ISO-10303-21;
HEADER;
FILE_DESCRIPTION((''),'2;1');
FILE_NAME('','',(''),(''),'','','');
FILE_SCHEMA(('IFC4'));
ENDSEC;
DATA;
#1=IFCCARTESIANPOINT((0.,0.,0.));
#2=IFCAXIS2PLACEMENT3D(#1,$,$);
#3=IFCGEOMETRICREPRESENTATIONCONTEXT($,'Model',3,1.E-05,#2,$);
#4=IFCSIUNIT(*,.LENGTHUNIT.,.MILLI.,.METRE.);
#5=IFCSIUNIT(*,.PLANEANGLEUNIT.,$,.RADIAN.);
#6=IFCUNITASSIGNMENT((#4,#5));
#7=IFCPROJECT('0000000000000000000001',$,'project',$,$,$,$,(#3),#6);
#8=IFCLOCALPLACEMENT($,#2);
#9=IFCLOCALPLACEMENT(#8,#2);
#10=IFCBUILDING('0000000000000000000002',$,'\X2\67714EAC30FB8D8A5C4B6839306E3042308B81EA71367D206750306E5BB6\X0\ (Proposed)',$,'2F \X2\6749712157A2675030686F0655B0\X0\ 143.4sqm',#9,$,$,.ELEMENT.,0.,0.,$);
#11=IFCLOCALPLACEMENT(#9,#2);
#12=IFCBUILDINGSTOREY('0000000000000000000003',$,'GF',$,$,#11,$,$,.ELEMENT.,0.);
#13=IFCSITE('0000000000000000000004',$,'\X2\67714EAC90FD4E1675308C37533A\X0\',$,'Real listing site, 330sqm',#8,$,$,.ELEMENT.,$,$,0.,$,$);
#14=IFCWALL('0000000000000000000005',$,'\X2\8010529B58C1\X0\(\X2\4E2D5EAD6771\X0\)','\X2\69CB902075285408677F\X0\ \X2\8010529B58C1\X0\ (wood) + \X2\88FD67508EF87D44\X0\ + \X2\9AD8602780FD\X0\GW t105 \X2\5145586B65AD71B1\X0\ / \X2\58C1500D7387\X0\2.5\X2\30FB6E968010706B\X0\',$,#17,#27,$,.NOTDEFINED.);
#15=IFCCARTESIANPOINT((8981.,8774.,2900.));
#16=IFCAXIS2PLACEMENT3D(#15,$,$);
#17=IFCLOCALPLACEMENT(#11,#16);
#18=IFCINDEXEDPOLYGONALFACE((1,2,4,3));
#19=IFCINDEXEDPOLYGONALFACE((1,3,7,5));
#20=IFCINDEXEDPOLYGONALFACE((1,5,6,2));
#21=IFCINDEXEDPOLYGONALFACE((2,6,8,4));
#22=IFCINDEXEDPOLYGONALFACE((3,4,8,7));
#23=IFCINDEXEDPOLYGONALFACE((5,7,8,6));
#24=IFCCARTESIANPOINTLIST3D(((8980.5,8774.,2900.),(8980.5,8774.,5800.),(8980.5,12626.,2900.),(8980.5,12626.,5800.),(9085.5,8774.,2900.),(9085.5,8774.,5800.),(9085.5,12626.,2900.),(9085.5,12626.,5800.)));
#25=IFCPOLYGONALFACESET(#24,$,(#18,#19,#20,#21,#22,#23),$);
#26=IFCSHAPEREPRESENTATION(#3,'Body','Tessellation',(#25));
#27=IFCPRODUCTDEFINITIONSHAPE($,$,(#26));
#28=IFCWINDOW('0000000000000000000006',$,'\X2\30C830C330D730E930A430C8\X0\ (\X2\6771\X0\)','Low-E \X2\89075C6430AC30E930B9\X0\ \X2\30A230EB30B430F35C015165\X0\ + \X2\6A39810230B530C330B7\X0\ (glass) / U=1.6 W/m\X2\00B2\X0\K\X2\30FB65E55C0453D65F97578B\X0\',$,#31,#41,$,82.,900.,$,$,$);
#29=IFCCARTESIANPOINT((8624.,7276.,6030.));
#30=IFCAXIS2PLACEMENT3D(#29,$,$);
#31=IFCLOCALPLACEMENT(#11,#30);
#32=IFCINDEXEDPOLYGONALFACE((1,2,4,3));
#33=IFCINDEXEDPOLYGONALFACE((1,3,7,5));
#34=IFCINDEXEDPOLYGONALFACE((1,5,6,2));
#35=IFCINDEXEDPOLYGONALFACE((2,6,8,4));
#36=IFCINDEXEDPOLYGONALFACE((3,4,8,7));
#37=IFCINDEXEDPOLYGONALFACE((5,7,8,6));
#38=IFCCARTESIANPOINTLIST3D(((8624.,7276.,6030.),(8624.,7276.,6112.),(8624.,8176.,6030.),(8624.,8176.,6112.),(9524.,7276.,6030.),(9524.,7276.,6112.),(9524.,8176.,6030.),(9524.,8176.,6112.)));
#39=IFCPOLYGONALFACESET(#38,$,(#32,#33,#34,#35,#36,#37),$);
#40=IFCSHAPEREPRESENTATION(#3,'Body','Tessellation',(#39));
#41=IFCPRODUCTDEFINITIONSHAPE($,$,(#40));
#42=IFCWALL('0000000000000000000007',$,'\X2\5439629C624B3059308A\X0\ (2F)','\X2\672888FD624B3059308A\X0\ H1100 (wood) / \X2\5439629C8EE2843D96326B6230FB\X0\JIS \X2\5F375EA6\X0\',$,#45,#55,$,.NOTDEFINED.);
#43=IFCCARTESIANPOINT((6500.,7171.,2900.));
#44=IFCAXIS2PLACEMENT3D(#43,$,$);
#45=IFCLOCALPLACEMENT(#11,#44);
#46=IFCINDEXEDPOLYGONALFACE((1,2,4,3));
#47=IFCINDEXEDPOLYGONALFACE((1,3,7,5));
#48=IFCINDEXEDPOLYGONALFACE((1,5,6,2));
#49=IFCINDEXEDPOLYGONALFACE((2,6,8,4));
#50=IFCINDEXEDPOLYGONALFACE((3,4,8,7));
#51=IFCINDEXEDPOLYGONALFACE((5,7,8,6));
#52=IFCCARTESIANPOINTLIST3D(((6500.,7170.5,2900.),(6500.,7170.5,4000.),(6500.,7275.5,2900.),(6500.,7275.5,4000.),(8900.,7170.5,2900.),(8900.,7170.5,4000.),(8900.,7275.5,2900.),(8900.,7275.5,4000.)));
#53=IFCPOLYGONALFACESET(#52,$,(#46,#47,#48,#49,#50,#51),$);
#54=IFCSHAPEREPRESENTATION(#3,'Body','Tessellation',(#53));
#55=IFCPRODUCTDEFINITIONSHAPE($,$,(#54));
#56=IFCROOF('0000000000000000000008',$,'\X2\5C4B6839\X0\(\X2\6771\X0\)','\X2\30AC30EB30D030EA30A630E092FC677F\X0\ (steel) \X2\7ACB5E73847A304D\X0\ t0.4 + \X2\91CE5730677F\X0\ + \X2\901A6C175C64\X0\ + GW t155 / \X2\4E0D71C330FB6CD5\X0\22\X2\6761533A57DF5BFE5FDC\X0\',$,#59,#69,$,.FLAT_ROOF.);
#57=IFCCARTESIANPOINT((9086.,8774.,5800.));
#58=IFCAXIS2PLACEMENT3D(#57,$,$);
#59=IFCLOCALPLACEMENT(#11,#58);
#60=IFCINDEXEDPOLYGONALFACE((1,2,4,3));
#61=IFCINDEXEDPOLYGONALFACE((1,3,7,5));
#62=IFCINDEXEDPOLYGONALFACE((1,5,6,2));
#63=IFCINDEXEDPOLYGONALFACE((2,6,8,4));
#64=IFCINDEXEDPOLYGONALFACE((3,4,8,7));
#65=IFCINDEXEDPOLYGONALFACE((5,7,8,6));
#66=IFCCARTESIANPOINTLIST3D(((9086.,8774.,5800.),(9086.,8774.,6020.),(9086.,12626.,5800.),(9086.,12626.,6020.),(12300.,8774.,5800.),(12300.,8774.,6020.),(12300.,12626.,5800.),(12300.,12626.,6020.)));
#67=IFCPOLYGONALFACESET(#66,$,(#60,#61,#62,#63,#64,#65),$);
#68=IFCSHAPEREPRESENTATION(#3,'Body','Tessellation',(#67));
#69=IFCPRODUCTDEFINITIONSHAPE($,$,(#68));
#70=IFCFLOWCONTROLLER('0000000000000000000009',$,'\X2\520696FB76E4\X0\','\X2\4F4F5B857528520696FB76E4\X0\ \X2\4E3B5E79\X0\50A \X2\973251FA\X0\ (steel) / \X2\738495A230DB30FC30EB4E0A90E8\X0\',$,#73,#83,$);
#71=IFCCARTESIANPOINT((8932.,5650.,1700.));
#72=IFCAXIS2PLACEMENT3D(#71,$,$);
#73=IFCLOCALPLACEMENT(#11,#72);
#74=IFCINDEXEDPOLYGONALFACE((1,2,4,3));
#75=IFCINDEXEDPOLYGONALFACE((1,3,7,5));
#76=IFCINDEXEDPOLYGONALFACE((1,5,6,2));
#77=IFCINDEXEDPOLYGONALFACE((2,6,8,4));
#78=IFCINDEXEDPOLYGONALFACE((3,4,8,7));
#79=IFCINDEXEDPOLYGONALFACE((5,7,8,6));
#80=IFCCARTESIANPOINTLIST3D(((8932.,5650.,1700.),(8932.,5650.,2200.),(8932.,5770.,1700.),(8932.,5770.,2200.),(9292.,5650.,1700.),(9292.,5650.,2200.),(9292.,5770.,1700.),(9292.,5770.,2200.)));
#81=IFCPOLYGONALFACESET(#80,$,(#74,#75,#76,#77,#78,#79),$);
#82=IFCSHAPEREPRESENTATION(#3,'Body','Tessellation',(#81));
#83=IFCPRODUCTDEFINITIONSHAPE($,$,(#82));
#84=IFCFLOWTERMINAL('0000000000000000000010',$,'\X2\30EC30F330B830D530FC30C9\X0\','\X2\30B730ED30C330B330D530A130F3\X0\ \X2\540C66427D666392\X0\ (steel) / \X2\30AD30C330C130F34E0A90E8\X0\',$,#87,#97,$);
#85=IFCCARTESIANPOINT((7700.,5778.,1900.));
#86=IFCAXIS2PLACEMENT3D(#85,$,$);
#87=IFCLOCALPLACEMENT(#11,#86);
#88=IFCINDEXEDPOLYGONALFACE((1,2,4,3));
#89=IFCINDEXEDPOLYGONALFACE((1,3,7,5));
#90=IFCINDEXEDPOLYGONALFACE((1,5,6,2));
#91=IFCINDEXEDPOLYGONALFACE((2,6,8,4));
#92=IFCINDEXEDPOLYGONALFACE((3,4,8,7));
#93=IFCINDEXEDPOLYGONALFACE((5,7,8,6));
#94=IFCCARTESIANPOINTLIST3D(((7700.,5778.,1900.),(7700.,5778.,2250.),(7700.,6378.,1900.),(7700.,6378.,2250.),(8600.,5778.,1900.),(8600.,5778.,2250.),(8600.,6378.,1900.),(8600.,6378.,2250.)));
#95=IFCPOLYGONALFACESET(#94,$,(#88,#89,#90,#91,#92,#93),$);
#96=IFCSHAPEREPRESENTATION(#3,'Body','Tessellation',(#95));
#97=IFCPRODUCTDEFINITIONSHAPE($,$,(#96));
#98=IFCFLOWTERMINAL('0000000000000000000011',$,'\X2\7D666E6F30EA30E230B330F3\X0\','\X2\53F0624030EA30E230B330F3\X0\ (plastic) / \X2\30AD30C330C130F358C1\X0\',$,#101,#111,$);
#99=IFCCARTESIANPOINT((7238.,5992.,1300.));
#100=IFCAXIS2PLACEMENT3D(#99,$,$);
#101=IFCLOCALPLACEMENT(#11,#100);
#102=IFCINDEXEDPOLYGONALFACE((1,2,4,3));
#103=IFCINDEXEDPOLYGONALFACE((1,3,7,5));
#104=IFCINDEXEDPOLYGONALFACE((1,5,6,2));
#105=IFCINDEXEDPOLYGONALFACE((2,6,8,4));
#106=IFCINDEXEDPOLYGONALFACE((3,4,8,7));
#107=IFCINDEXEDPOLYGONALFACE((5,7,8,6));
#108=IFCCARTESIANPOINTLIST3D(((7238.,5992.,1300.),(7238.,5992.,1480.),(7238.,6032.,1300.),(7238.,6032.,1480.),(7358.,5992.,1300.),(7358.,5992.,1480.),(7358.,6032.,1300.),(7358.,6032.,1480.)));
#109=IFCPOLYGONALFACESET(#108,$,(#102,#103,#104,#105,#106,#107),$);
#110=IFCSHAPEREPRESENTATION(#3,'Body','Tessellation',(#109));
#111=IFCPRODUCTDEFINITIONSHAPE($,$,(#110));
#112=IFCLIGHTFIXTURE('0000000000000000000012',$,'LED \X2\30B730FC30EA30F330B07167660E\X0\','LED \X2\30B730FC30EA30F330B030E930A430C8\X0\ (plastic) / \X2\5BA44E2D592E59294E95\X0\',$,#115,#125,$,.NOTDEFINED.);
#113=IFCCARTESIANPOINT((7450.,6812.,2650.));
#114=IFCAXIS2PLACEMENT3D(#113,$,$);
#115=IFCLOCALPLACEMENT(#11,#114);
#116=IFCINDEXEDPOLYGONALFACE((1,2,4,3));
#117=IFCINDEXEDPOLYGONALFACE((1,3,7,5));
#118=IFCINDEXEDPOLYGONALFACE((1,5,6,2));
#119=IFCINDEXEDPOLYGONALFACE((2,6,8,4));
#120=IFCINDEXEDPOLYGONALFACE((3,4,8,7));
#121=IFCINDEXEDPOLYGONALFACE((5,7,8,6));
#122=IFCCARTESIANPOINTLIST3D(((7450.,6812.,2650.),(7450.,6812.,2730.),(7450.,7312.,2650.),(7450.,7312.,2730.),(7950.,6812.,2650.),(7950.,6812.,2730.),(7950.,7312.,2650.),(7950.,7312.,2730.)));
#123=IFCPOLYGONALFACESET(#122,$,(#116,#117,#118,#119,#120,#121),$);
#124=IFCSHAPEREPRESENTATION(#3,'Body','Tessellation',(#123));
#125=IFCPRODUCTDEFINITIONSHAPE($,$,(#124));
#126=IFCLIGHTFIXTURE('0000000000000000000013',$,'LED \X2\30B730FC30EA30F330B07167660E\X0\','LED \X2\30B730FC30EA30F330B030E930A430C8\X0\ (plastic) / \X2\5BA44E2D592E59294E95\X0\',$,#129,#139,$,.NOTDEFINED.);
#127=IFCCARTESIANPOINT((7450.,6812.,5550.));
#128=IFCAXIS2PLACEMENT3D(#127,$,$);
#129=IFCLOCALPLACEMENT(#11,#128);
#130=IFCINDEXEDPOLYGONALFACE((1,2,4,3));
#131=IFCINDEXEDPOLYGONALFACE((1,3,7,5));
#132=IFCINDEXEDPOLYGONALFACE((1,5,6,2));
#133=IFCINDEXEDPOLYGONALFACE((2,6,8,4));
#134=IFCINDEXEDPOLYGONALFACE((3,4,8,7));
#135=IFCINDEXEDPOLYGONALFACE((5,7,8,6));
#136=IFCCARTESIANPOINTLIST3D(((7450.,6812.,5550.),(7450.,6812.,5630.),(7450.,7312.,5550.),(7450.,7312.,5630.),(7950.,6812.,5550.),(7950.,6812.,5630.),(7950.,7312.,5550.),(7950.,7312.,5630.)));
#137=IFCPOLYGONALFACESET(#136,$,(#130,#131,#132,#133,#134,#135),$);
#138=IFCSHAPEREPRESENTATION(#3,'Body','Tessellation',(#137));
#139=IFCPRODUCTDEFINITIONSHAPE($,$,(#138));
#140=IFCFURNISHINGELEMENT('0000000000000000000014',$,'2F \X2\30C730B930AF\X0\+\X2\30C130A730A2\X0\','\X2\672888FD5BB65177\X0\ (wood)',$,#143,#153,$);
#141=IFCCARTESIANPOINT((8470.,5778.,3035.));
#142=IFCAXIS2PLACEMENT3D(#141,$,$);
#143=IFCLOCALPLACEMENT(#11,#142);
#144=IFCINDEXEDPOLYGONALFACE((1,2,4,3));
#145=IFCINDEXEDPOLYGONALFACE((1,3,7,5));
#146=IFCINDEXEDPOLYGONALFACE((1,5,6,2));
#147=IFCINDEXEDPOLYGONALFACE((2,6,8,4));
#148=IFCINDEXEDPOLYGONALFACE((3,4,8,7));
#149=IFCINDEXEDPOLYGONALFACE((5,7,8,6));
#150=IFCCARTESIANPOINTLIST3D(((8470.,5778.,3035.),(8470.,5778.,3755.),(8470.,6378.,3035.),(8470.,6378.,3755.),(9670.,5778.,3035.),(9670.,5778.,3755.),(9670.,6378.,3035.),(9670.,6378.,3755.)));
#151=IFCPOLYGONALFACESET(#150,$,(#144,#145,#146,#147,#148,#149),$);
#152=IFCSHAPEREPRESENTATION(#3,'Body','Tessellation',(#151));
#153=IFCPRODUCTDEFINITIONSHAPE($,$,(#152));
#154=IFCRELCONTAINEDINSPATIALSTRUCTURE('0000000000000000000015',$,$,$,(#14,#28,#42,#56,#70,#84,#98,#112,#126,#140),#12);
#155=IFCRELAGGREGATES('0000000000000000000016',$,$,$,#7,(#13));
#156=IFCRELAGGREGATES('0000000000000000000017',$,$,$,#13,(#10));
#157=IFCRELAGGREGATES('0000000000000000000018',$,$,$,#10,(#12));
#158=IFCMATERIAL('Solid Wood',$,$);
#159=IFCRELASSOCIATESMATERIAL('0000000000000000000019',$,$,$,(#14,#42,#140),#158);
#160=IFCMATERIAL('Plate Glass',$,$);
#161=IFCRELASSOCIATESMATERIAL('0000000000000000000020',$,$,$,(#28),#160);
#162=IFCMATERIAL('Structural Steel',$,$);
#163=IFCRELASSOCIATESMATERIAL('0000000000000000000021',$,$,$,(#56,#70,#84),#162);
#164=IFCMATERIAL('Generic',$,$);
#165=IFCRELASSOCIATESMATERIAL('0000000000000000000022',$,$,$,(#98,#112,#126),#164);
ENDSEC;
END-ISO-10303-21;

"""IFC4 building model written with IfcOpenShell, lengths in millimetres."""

from ifc_helpers import new_model, si_unit, frame, frame_2d, origin, place, context, project, spatial, rectangle, extrude, material, element, save


model = new_model("IFC4")

# Units and contexts
model_context = context("Model", 3, precision=1e-05, world=origin())
ifc_project = project(units=[si_unit("LENGTHUNIT", "METRE", prefix="MILLI"), si_unit("PLANEANGLEUNIT", "RADIAN")], contexts=[model_context])

# Site, building, storey
site_placement = place(None, origin())
site = spatial("IfcSite", under=ifc_project, at=site_placement, Name="東京都世田谷区", ObjectType="Real listing site, 330sqm", CompositionType="ELEMENT", RefElevation=0.0)
building_placement = place(site_placement, origin())
building = spatial("IfcBuilding", under=site, at=building_placement, Name="東京・越屋根のある自然素材の家 (Proposed)", ObjectType="2F 杉無垢材と漆喰 143.4sqm", CompositionType="ELEMENT", ElevationOfRefHeight=0.0, ElevationOfTerrain=0.0)
storey_placement = place(building_placement, origin())
storey = spatial("IfcBuildingStorey", under=building, at=storey_placement, Name="GF", CompositionType="ELEMENT", Elevation=0.0)

# Shared definitions
ifc_material_1 = material(Name="Solid Wood")

# Shared definitions
ifc_material_2 = material(Name="Plate Glass")

# Wall
wall_1_placement = place(storey_placement, frame((8981.0, 8774.0, 2900.0)))
element("IfcWall", 1, at=wall_1_placement, inside=storey, material=ifc_material_1, Name="耐力壁(中庭東)", Description="構造用合板 耐力壁 (wood) + 製材軸組 + 高性能GW t105 充填断熱 / 壁倍率2.5・準耐火", PredefinedType="NOTDEFINED", context=model_context, shape_type="SweptSolid", body=[
    extrude(rectangle(XDim=105.0, YDim=3852.0, at=frame_2d((52.0, 1926.0))), frame((8981.0, 8774.0, 2900.0)), (0.0, 0.0, 1.0), 2900.0),
])

# Window
window_1_placement = place(storey_placement, frame((8624.0, 7276.0, 6030.0)))
element("IfcWindow", 2, at=window_1_placement, inside=storey, material=ifc_material_2, Name="トップライト (東)", Description="Low-E 複層ガラス アルゴン封入 + 樹脂サッシ (glass) / U=1.6 W/m²K・日射取得型", OverallHeight=82.0, OverallWidth=900.0, context=model_context, shape_type="SweptSolid", body=[
    extrude(rectangle(XDim=900.0, YDim=900.0, at=frame_2d((450.0, 450.0))), frame((8624.0, 7276.0, 6030.0)), (0.0, 0.0, 1.0), 82.0),
])

# Wall
wall_2_placement = place(storey_placement, frame((6500.0, 7171.0, 2900.0)))
element("IfcWall", 3, at=wall_2_placement, inside=storey, material=ifc_material_1, Name="吹抜手すり (2F)", Description="木製手すり H1100 (wood) / 吹抜転落防止・JIS 強度", PredefinedType="NOTDEFINED", context=model_context, shape_type="SweptSolid", body=[
    extrude(rectangle(XDim=2400.0, YDim=105.0, at=frame_2d((1200.0, 52.0))), frame((6500.0, 7171.0, 2900.0)), (0.0, 0.0, 1.0), 1100.0),
])

# Roof
ifc_material_3 = material(Name="Structural Steel")
for number, where, name in (
    (4, (9086.0, 8774.0, 5800.0), "屋根(東)"),
):
    element("IfcRoof", number, at=place(storey_placement, frame(where)), inside=storey, material=ifc_material_3, Name=name, Description="ガルバリウム鋼板 (steel) 立平葺き t0.4 + 野地板 + 通気層 + GW t155 / 不燃・法22条区域対応", PredefinedType="FLAT_ROOF", context=model_context, shape_type="SweptSolid", body=[
        extrude(rectangle(XDim=3214.0, YDim=3852.0, at=frame_2d((1607.0, 1926.0))), frame((9086.0, 8774.0, 5800.0)), (0.0, 0.0, 1.0), 220.0),
    ])

# Flow controller
flow_controller_placement = place(storey_placement, frame((8932.0, 5650.0, 1700.0)))
element("IfcFlowController", 5, at=flow_controller_placement, inside=storey, material=ifc_material_3, Name="分電盤", Description="住宅用分電盤 主幹50A 露出 (steel) / 玄関ホール上部", context=model_context, shape_type="SweptSolid", body=[
    extrude(rectangle(XDim=360.0, YDim=120.0, at=frame_2d((180.0, 60.0))), frame((8932.0, 5650.0, 1700.0)), (0.0, 0.0, 1.0), 500.0),
])

# Flow terminals
flow_terminal_1_placement = place(storey_placement, frame((7700.0, 5778.0, 1900.0)))
element("IfcFlowTerminal", 6, at=flow_terminal_1_placement, inside=storey, material=ifc_material_3, Name="レンジフード", Description="シロッコファン 同時給排 (steel) / キッチン上部", context=model_context, shape_type="SweptSolid", body=[
    extrude(rectangle(XDim=900.0, YDim=600.0, at=frame_2d((450.0, 300.0))), frame((7700.0, 5778.0, 1900.0)), (0.0, 0.0, 1.0), 350.0),
])
ifc_material_4 = material(Name="Generic")
flow_terminal_2_placement = place(storey_placement, frame((7238.0, 5992.0, 1300.0)))
element("IfcFlowTerminal", 7, at=flow_terminal_2_placement, inside=storey, material=ifc_material_4, Name="給湯リモコン", Description="台所リモコン (plastic) / キッチン壁", context=model_context, shape_type="SweptSolid", body=[
    extrude(rectangle(XDim=120.0, YDim=40.0, at=frame_2d((60.0, 20.0))), frame((7238.0, 5992.0, 1300.0)), (0.0, 0.0, 1.0), 180.0),
])

# Light fixtures
light_fixture_1_placement = place(storey_placement, frame((7450.0, 6812.0, 2650.0)))
element("IfcLightFixture", 8, at=light_fixture_1_placement, inside=storey, material=ifc_material_4, Name="LED シーリング照明", Description="LED シーリングライト (plastic) / 室中央天井", PredefinedType="NOTDEFINED", context=model_context, shape_type="SweptSolid", body=[
    extrude(rectangle(XDim=500.0, YDim=500.0, at=frame_2d((250.0, 250.0))), frame((7450.0, 6812.0, 2650.0)), (0.0, 0.0, 1.0), 80.0),
])
light_fixture_2_placement = place(storey_placement, frame((7450.0, 6812.0, 5550.0)))
element("IfcLightFixture", 9, at=light_fixture_2_placement, inside=storey, material=ifc_material_4, Name="LED シーリング照明", Description="LED シーリングライト (plastic) / 室中央天井", PredefinedType="NOTDEFINED", context=model_context, shape_type="SweptSolid", body=[
    extrude(rectangle(XDim=500.0, YDim=500.0, at=frame_2d((250.0, 250.0))), frame((7450.0, 6812.0, 5550.0)), (0.0, 0.0, 1.0), 80.0),
])

# Furnishing element
furnishing_placement = place(storey_placement, frame((8470.0, 5778.0, 3035.0)))
element("IfcFurnishingElement", 10, at=furnishing_placement, inside=storey, material=ifc_material_1, Name="2F デスク+チェア", Description="木製家具 (wood)", context=model_context, shape_type="SweptSolid", body=[
    extrude(rectangle(XDim=1200.0, YDim=600.0, at=frame_2d((600.0, 300.0))), frame((8470.0, 5778.0, 3035.0)), (0.0, 0.0, 1.0), 720.0),
])

save(model, "model.ifc")
